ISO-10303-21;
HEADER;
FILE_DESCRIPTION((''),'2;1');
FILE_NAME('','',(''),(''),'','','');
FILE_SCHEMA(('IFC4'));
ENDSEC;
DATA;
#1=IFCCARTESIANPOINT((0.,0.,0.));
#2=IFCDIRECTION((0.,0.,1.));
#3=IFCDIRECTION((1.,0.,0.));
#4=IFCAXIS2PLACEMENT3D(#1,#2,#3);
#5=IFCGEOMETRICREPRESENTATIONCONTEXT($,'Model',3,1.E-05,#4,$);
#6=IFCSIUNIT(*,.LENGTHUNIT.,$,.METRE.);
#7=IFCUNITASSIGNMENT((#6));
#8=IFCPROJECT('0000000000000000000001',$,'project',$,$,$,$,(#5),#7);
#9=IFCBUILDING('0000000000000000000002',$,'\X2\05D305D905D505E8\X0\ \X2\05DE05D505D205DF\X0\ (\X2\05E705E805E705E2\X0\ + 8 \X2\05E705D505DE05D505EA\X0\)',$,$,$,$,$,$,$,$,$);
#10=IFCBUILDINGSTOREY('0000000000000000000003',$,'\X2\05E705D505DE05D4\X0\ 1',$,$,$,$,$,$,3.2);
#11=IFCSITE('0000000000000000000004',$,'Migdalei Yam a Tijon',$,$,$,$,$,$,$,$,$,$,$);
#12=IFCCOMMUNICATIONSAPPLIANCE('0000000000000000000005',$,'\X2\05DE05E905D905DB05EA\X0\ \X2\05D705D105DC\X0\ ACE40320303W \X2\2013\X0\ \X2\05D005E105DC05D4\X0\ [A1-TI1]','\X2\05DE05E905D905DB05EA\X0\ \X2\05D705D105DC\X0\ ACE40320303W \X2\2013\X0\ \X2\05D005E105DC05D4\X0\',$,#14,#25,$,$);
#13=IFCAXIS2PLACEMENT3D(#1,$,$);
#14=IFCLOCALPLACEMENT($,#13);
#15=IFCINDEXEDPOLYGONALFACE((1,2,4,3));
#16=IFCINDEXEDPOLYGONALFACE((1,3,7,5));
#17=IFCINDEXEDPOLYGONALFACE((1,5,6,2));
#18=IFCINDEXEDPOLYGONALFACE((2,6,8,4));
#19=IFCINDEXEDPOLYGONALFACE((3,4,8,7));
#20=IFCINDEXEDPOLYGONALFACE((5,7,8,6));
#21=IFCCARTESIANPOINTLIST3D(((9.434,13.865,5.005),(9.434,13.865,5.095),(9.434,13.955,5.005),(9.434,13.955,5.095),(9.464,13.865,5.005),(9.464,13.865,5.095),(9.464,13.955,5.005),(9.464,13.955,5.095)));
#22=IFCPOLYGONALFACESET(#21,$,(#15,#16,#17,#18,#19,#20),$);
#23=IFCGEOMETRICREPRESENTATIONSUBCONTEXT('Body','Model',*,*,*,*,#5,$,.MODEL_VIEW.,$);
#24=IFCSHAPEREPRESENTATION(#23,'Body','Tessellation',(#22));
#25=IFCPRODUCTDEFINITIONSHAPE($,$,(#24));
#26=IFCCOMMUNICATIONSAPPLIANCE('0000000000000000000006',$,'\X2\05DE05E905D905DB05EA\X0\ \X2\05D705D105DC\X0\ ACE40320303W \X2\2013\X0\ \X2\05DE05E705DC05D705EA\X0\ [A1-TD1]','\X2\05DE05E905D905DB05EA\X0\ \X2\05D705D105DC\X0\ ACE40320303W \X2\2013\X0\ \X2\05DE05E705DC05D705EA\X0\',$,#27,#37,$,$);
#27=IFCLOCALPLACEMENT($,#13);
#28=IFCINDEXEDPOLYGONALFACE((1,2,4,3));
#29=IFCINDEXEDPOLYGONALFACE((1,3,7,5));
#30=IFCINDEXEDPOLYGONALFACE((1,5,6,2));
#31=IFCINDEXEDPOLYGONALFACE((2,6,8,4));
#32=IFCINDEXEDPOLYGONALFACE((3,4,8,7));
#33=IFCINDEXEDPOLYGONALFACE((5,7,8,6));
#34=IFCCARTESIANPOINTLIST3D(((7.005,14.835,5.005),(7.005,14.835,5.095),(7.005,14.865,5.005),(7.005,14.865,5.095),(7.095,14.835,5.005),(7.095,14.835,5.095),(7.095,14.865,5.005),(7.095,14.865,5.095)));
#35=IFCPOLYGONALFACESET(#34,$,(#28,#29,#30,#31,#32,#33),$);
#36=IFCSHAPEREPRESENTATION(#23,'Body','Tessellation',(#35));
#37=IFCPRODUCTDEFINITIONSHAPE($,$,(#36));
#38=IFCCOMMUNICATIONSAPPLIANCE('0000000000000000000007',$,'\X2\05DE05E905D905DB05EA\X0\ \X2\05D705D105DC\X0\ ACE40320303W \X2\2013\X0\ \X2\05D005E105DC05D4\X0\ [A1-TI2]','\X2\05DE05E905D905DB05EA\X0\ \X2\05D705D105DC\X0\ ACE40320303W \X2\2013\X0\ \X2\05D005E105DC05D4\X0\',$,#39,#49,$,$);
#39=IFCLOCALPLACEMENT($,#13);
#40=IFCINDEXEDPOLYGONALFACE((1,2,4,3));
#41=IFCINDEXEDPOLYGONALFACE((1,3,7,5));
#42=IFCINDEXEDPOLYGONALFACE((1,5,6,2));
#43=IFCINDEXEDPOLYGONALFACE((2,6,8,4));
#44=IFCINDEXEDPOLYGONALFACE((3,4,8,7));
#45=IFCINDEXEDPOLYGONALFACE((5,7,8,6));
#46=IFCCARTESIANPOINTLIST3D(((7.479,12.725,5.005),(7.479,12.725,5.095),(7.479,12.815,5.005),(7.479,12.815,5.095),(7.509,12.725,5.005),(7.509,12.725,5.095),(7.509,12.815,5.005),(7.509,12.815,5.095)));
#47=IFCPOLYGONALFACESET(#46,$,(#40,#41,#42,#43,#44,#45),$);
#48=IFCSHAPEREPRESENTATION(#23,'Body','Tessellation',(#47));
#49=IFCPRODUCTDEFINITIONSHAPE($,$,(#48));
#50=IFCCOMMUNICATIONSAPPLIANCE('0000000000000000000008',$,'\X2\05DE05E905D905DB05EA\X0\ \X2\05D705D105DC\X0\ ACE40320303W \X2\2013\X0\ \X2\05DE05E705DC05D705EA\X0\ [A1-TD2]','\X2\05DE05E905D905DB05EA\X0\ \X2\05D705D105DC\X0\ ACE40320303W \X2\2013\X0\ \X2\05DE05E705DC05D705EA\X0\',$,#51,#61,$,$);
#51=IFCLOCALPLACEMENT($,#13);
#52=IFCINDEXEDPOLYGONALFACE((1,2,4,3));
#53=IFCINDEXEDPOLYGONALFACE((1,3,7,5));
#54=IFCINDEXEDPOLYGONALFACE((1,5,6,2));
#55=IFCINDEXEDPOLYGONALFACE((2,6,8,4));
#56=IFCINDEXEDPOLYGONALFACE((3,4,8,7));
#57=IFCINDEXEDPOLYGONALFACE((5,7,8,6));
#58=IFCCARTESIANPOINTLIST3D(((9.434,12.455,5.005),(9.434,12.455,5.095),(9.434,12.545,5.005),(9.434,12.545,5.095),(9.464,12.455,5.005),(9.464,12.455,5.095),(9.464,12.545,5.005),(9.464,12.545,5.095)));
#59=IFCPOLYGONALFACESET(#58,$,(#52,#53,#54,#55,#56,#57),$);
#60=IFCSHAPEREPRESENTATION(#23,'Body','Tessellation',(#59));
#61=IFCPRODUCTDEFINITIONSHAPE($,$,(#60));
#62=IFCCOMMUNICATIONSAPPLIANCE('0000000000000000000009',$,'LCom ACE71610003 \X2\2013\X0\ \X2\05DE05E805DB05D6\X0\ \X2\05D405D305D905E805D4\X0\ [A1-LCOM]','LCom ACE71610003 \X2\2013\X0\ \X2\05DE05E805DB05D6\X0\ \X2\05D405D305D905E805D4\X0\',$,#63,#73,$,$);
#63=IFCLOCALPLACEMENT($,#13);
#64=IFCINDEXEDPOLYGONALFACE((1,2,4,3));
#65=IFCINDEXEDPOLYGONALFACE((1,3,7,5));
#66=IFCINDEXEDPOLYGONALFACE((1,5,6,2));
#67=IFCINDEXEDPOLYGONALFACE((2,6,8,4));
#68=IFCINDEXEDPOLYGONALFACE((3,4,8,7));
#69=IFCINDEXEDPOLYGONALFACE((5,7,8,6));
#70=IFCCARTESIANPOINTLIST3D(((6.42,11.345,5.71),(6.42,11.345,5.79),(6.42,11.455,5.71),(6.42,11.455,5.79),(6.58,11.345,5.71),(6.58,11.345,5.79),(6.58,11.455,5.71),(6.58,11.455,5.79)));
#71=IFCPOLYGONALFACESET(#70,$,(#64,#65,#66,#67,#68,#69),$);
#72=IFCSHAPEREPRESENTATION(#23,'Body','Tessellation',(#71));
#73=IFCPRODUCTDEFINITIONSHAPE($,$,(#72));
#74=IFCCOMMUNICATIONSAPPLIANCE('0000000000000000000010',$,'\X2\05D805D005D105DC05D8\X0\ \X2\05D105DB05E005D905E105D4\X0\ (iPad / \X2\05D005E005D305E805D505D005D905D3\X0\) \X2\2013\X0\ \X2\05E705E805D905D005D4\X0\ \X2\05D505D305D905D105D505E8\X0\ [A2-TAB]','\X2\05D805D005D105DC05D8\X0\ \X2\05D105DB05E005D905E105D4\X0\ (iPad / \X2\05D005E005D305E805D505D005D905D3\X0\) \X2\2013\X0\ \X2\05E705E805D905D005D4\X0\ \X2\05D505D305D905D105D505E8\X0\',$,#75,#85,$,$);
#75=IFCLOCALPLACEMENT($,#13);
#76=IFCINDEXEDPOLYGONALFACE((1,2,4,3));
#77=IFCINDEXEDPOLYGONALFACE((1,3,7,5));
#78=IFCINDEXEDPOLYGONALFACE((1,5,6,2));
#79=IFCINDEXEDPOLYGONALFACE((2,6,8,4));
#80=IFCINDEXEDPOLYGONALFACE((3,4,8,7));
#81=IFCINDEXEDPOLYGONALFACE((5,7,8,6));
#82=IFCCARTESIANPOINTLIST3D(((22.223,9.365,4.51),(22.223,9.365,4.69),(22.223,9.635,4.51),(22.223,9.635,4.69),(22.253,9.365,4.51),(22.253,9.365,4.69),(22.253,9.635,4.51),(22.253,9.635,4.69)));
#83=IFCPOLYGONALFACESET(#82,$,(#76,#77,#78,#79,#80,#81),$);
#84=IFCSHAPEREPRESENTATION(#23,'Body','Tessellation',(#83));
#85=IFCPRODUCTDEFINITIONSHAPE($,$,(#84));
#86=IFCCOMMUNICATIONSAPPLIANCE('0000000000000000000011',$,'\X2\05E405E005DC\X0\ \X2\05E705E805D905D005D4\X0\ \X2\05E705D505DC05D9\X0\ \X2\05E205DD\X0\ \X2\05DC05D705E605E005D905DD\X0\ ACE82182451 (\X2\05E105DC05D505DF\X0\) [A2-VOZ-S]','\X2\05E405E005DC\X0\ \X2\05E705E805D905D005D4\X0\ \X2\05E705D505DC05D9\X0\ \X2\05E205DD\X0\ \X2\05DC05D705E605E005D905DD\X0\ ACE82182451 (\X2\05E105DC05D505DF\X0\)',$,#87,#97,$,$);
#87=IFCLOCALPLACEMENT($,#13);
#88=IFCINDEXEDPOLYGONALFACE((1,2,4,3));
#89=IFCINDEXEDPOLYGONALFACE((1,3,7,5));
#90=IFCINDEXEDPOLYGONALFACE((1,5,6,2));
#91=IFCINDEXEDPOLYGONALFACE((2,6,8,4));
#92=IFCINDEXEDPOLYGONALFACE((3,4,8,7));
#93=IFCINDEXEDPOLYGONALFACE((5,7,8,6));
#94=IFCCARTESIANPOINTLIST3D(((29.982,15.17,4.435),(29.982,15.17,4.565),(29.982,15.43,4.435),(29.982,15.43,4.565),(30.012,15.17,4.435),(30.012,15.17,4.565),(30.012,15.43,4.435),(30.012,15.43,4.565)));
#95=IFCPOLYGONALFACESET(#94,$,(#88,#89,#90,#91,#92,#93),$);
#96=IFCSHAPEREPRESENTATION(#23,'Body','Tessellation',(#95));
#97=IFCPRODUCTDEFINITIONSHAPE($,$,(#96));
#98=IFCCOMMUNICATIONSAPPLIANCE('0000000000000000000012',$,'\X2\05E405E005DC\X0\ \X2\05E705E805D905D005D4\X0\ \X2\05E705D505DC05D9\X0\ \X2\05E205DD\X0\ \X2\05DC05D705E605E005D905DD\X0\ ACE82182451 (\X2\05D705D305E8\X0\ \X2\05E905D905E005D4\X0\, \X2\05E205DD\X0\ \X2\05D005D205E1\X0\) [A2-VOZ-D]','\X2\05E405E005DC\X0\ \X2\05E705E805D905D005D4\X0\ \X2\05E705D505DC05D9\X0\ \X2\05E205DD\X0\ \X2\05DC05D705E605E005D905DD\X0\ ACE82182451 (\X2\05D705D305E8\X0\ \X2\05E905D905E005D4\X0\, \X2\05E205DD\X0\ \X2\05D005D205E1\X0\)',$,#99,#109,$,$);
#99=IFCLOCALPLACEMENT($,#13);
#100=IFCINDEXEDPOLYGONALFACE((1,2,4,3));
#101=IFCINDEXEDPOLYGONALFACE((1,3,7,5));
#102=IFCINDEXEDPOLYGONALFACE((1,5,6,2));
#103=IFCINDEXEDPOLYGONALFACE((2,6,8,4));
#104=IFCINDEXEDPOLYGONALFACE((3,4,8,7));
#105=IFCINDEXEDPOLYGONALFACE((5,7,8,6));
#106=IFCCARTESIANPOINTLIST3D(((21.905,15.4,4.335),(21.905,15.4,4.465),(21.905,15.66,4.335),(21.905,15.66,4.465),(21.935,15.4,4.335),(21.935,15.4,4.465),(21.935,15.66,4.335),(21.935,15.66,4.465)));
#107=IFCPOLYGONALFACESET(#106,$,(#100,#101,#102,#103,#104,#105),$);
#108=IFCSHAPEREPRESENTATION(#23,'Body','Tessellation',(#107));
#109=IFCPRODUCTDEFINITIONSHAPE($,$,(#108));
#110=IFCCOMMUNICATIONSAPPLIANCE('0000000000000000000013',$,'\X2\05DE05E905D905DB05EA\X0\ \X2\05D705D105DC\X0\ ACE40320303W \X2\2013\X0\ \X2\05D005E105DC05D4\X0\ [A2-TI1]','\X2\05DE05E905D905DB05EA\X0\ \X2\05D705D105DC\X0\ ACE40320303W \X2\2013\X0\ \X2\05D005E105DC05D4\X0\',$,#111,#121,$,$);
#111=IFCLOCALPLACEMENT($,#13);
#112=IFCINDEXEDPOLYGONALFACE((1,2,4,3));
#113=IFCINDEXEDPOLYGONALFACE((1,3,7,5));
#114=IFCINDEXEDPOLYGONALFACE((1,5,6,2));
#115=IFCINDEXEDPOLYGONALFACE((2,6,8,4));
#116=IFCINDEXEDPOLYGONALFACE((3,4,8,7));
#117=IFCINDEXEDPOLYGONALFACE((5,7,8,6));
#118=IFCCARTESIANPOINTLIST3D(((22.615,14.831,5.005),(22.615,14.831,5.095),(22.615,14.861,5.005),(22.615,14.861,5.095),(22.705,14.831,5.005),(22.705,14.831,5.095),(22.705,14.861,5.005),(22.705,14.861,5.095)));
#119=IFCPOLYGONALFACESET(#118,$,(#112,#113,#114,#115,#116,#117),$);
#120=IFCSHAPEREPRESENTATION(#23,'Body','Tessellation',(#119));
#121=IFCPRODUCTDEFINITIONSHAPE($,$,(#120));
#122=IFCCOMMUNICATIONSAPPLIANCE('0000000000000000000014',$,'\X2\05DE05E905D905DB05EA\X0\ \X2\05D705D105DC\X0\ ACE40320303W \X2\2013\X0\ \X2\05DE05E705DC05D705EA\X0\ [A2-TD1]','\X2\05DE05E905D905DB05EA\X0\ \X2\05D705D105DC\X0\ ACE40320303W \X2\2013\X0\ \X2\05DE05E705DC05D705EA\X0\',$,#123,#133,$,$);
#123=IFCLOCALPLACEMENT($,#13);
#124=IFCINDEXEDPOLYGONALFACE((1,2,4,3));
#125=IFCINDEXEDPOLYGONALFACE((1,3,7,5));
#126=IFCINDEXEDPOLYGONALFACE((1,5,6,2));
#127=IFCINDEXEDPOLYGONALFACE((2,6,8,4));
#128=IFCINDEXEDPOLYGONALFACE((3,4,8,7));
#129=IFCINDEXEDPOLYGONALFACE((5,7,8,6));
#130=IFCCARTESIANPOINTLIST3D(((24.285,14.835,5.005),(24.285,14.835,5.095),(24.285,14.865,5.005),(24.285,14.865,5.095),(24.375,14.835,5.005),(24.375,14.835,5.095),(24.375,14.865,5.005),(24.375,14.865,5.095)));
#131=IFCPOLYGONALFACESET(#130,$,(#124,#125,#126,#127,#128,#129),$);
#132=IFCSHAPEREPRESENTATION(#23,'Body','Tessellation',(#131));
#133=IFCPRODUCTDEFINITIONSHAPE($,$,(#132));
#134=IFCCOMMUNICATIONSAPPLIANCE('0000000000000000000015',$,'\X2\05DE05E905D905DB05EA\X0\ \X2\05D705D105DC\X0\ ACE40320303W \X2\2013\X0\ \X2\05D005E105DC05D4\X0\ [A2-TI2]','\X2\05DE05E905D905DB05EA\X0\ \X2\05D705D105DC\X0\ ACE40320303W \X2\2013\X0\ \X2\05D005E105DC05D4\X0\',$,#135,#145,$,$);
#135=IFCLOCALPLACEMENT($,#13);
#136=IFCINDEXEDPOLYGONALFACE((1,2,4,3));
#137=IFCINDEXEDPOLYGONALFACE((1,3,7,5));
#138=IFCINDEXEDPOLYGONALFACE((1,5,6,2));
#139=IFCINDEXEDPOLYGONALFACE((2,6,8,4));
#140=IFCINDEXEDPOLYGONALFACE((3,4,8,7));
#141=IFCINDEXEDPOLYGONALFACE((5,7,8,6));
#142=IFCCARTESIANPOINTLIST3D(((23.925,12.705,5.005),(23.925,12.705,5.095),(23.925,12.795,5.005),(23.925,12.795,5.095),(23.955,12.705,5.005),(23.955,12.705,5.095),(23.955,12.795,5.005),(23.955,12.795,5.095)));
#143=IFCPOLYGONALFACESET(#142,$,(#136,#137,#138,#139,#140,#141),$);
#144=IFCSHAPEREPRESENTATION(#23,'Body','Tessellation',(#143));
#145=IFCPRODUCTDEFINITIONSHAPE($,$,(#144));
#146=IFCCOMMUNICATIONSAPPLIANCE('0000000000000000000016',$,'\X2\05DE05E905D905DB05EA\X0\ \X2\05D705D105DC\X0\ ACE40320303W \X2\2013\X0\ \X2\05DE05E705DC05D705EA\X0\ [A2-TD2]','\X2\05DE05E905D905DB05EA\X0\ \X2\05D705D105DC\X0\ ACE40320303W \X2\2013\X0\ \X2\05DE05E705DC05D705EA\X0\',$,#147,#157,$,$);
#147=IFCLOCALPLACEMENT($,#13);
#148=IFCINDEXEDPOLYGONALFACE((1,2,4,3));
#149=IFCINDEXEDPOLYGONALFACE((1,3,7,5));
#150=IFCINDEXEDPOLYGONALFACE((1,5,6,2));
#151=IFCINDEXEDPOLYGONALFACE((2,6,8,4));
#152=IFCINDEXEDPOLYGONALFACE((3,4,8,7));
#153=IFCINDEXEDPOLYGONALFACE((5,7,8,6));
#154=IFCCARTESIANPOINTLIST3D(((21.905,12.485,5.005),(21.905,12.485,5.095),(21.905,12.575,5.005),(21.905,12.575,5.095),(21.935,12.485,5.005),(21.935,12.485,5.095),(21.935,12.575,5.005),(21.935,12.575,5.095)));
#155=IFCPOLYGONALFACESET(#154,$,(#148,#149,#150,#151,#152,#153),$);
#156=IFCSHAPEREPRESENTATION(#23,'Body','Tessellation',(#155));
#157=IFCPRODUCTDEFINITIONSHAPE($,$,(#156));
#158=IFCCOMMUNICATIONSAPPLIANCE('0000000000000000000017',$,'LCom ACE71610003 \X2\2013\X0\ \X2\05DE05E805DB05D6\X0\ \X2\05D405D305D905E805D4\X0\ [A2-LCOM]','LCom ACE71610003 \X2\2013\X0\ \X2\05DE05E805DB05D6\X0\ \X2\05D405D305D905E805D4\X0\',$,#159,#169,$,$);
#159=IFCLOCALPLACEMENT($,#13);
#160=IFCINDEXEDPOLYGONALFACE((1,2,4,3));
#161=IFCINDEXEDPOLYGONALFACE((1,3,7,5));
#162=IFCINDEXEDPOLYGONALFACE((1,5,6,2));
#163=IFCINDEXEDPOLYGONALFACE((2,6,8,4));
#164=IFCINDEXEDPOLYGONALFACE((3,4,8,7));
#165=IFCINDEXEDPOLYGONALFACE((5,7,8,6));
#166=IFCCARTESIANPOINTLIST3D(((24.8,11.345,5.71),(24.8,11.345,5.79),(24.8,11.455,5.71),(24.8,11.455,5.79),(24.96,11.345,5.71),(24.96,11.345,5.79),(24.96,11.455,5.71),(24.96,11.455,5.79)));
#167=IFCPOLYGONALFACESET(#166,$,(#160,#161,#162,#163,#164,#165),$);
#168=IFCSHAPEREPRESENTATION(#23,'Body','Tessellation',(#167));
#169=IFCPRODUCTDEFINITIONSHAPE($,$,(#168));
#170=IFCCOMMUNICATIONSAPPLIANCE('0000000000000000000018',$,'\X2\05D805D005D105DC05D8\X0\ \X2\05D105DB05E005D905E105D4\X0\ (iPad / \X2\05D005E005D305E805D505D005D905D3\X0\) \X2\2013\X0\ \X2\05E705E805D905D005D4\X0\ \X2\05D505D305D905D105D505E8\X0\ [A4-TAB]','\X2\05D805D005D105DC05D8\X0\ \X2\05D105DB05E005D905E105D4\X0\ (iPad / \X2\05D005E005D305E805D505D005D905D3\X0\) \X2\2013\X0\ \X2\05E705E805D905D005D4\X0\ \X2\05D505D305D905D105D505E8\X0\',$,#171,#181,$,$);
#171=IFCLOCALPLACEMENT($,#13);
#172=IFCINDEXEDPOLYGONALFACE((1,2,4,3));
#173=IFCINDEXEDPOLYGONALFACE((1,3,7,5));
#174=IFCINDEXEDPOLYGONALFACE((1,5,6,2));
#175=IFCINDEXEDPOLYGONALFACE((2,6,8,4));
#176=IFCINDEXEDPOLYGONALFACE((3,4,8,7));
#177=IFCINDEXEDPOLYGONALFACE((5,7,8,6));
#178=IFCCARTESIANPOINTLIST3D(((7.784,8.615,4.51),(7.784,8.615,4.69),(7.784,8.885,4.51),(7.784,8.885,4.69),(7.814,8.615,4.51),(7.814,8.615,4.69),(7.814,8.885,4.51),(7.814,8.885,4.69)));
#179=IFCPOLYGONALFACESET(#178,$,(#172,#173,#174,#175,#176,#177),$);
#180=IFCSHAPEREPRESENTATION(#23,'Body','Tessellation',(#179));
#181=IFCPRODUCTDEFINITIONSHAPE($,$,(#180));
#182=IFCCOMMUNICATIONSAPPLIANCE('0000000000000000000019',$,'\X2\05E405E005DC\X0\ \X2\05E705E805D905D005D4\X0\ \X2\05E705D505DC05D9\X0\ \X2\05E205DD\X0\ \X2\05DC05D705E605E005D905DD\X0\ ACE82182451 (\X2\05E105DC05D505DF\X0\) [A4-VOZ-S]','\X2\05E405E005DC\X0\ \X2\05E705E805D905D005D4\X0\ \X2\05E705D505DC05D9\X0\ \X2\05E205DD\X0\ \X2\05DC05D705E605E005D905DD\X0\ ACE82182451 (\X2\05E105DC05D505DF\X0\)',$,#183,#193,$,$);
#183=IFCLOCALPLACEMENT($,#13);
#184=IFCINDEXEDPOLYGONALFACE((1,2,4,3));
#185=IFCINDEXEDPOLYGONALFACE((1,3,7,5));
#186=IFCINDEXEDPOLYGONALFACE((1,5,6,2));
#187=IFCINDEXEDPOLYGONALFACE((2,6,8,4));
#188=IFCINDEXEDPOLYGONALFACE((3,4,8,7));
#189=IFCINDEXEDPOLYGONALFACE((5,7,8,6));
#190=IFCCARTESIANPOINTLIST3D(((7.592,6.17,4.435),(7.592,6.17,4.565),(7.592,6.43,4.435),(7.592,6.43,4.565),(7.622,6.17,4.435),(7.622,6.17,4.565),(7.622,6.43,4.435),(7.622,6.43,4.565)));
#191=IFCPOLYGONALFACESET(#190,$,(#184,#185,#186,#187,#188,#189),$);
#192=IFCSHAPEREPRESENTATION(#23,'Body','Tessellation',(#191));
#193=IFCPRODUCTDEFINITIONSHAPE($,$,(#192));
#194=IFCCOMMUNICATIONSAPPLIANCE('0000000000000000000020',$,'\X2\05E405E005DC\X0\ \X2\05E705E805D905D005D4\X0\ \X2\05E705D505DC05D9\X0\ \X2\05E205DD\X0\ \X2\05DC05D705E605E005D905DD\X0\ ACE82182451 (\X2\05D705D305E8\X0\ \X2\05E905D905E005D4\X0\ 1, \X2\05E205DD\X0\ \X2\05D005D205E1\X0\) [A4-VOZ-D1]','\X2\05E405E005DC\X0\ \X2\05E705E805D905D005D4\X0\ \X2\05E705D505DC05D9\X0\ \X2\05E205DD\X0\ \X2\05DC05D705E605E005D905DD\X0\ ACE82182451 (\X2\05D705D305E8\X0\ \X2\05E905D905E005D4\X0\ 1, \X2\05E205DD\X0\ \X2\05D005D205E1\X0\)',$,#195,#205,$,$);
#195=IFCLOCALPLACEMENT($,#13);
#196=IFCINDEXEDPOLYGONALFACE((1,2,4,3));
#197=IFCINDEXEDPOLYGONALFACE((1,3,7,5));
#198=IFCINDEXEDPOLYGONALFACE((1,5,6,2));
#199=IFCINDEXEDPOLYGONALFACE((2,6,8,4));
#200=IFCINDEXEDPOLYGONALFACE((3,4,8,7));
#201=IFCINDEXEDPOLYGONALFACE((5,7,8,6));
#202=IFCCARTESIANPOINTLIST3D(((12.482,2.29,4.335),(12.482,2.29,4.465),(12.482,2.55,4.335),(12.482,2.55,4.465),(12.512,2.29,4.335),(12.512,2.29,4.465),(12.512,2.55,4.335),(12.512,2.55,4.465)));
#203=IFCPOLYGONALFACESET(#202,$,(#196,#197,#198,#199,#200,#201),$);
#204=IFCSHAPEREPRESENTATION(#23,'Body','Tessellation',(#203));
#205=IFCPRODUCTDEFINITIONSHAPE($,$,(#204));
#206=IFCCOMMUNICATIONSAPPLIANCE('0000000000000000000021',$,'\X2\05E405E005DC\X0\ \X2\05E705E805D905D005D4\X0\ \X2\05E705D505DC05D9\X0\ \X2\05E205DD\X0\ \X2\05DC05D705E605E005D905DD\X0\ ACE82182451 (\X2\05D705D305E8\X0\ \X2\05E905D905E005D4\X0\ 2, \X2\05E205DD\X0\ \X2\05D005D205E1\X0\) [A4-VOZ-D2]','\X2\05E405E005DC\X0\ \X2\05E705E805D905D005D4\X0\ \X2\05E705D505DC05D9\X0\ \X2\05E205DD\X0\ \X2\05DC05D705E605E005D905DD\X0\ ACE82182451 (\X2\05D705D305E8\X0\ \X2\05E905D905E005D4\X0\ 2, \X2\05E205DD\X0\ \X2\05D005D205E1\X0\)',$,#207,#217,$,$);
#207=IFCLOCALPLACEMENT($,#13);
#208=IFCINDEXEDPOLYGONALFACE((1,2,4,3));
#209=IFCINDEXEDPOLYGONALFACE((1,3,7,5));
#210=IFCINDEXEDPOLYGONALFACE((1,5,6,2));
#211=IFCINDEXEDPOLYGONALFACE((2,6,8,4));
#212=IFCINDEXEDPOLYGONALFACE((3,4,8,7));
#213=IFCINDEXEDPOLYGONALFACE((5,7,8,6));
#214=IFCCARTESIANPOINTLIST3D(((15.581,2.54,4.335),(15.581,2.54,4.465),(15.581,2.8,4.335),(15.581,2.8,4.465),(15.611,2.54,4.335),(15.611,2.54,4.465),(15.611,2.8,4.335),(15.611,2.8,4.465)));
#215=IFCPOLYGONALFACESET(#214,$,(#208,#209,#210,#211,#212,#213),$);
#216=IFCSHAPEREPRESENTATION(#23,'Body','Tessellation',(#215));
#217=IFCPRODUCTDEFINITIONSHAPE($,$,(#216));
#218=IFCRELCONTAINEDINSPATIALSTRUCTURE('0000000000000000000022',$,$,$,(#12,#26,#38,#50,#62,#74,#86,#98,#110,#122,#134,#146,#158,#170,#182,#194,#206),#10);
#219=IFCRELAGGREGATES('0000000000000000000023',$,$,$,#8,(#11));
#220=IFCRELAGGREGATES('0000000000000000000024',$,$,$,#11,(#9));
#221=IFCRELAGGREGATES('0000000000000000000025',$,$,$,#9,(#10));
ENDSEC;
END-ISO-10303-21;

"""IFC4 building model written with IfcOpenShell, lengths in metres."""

from ifc_helpers import new_model, si_unit, frame, origin_with_axes, context, subcontext, project, spatial, line, indexed_curve, outline, extrude, element, save


model = new_model("IFC4")

# Units and contexts
model_context = context("Model", 3, precision=1e-05, world=origin_with_axes())
body_context = subcontext(model_context, "Body", "Model", "MODEL_VIEW")
ifc_project = project(units=[si_unit("LENGTHUNIT", "METRE")], contexts=[model_context])

# Site, building, storey
site = spatial("IfcSite", under=ifc_project, Name="Migdalei Yam a Tijon")
building = spatial("IfcBuilding", under=site, Name="דיור מוגן (קרקע + 8 קומות)")
storey = spatial("IfcBuildingStorey", under=building, Name="קומה 1", Elevation=3.2)

# Communications appliances
element("IfcCommunicationsAppliance", 1, inside=storey, Name="משיכת חבל ACE40320303W – אסלה [A1-TI1]", Description="משיכת חבל ACE40320303W – אסלה", context=body_context, shape_type="SweptSolid", body=[
    extrude(outline(indexed_curve([(0.0, 0.0), (0.03, 0.0), (0.03, 0.09), (0.0, 0.09)], segments=[line(1, 2, 3, 4, 1)])), frame((9.434, 13.865, 5.005), z_axis=(0.0, 0.0, 1.0), x_axis=(1.0, 0.0, 0.0)), (0.0, 0.0, 1.0), 0.09),
])
element("IfcCommunicationsAppliance", 2, inside=storey, Name="משיכת חבל ACE40320303W – מקלחת [A1-TD1]", Description="משיכת חבל ACE40320303W – מקלחת", context=body_context, shape_type="SweptSolid", body=[
    extrude(outline(indexed_curve([(0.0, 0.0), (0.09, 0.0), (0.09, 0.03), (0.0, 0.03)], segments=[line(1, 2, 3, 4, 1)])), frame((7.005, 14.835, 5.005), z_axis=(0.0, 0.0, 1.0), x_axis=(1.0, 0.0, 0.0)), (0.0, 0.0, 1.0), 0.09),
])
element("IfcCommunicationsAppliance", 3, inside=storey, Name="משיכת חבל ACE40320303W – אסלה [A1-TI2]", Description="משיכת חבל ACE40320303W – אסלה", context=body_context, shape_type="SweptSolid", body=[
    extrude(outline(indexed_curve([(0.0, 0.0), (0.03, 0.0), (0.03, 0.09), (0.0, 0.09)], segments=[line(1, 2, 3, 4, 1)])), frame((7.479, 12.725, 5.005), z_axis=(0.0, 0.0, 1.0), x_axis=(1.0, 0.0, 0.0)), (0.0, 0.0, 1.0), 0.09),
])
element("IfcCommunicationsAppliance", 4, inside=storey, Name="משיכת חבל ACE40320303W – מקלחת [A1-TD2]", Description="משיכת חבל ACE40320303W – מקלחת", context=body_context, shape_type="SweptSolid", body=[
    extrude(outline(indexed_curve([(0.0, 0.0), (0.03, 0.0), (0.03, 0.09), (0.0, 0.09)], segments=[line(1, 2, 3, 4, 1)])), frame((9.434, 12.455, 5.005), z_axis=(0.0, 0.0, 1.0), x_axis=(1.0, 0.0, 0.0)), (0.0, 0.0, 1.0), 0.09),
])
element("IfcCommunicationsAppliance", 5, inside=storey, Name="LCom ACE71610003 – מרכז הדירה [A1-LCOM]", Description="LCom ACE71610003 – מרכז הדירה", context=body_context, shape_type="SweptSolid", body=[
    extrude(outline(indexed_curve([(0.0, 0.0), (0.16, 0.0), (0.16, 0.11), (0.0, 0.11)], segments=[line(1, 2, 3, 4, 1)])), frame((6.42, 11.345, 5.71), z_axis=(0.0, 0.0, 1.0), x_axis=(1.0, 0.0, 0.0)), (0.0, 0.0, 1.0), 0.08),
])
element("IfcCommunicationsAppliance", 6, inside=storey, Name="טאבלט בכניסה (iPad / אנדרואיד) – קריאה ודיבור [A2-TAB]", Description="טאבלט בכניסה (iPad / אנדרואיד) – קריאה ודיבור", context=body_context, shape_type="SweptSolid", body=[
    extrude(outline(indexed_curve([(0.0, 0.0), (0.03, 0.0), (0.03, 0.27), (0.0, 0.27)], segments=[line(1, 2, 3, 4, 1)])), frame((22.223, 9.365, 4.51), z_axis=(0.0, 0.0, 1.0), x_axis=(1.0, 0.0, 0.0)), (0.0, 0.0, 1.0), 0.18),
])
element("IfcCommunicationsAppliance", 7, inside=storey, Name="פנל קריאה קולי עם לחצנים ACE82182451 (סלון) [A2-VOZ-S]", Description="פנל קריאה קולי עם לחצנים ACE82182451 (סלון)", context=body_context, shape_type="SweptSolid", body=[
    extrude(outline(indexed_curve([(0.0, 0.0), (0.03, 0.0), (0.03, 0.26), (0.0, 0.26)], segments=[line(1, 2, 3, 4, 1)])), frame((29.982, 15.17, 4.435), z_axis=(0.0, 0.0, 1.0), x_axis=(1.0, 0.0, 0.0)), (0.0, 0.0, 1.0), 0.13),
])
element("IfcCommunicationsAppliance", 8, inside=storey, Name="פנל קריאה קולי עם לחצנים ACE82182451 (חדר שינה, עם אגס) [A2-VOZ-D]", Description="פנל קריאה קולי עם לחצנים ACE82182451 (חדר שינה, עם אגס)", context=body_context, shape_type="SweptSolid", body=[
    extrude(outline(indexed_curve([(0.0, 0.0), (0.03, 0.0), (0.03, 0.26), (0.0, 0.26)], segments=[line(1, 2, 3, 4, 1)])), frame((21.905, 15.4, 4.335), z_axis=(0.0, 0.0, 1.0), x_axis=(1.0, 0.0, 0.0)), (0.0, 0.0, 1.0), 0.13),
])
element("IfcCommunicationsAppliance", 9, inside=storey, Name="משיכת חבל ACE40320303W – אסלה [A2-TI1]", Description="משיכת חבל ACE40320303W – אסלה", context=body_context, shape_type="SweptSolid", body=[
    extrude(outline(indexed_curve([(0.0, 0.0), (0.09, 0.0), (0.09, 0.03), (0.0, 0.03)], segments=[line(1, 2, 3, 4, 1)])), frame((22.615, 14.831, 5.005), z_axis=(0.0, 0.0, 1.0), x_axis=(1.0, 0.0, 0.0)), (0.0, 0.0, 1.0), 0.09),
])
element("IfcCommunicationsAppliance", 10, inside=storey, Name="משיכת חבל ACE40320303W – מקלחת [A2-TD1]", Description="משיכת חבל ACE40320303W – מקלחת", context=body_context, shape_type="SweptSolid", body=[
    extrude(outline(indexed_curve([(0.0, 0.0), (0.09, 0.0), (0.09, 0.03), (0.0, 0.03)], segments=[line(1, 2, 3, 4, 1)])), frame((24.285, 14.835, 5.005), z_axis=(0.0, 0.0, 1.0), x_axis=(1.0, 0.0, 0.0)), (0.0, 0.0, 1.0), 0.09),
])
element("IfcCommunicationsAppliance", 11, inside=storey, Name="משיכת חבל ACE40320303W – אסלה [A2-TI2]", Description="משיכת חבל ACE40320303W – אסלה", context=body_context, shape_type="SweptSolid", body=[
    extrude(outline(indexed_curve([(0.0, 0.0), (0.03, 0.0), (0.03, 0.09), (0.0, 0.09)], segments=[line(1, 2, 3, 4, 1)])), frame((23.925, 12.705, 5.005), z_axis=(0.0, 0.0, 1.0), x_axis=(1.0, 0.0, 0.0)), (0.0, 0.0, 1.0), 0.09),
])
element("IfcCommunicationsAppliance", 12, inside=storey, Name="משיכת חבל ACE40320303W – מקלחת [A2-TD2]", Description="משיכת חבל ACE40320303W – מקלחת", context=body_context, shape_type="SweptSolid", body=[
    extrude(outline(indexed_curve([(0.0, 0.0), (0.03, 0.0), (0.03, 0.09), (0.0, 0.09)], segments=[line(1, 2, 3, 4, 1)])), frame((21.905, 12.485, 5.005), z_axis=(0.0, 0.0, 1.0), x_axis=(1.0, 0.0, 0.0)), (0.0, 0.0, 1.0), 0.09),
])
element("IfcCommunicationsAppliance", 13, inside=storey, Name="LCom ACE71610003 – מרכז הדירה [A2-LCOM]", Description="LCom ACE71610003 – מרכז הדירה", context=body_context, shape_type="SweptSolid", body=[
    extrude(outline(indexed_curve([(0.0, 0.0), (0.16, 0.0), (0.16, 0.11), (0.0, 0.11)], segments=[line(1, 2, 3, 4, 1)])), frame((24.8, 11.345, 5.71), z_axis=(0.0, 0.0, 1.0), x_axis=(1.0, 0.0, 0.0)), (0.0, 0.0, 1.0), 0.08),
])
element("IfcCommunicationsAppliance", 14, inside=storey, Name="טאבלט בכניסה (iPad / אנדרואיד) – קריאה ודיבור [A4-TAB]", Description="טאבלט בכניסה (iPad / אנדרואיד) – קריאה ודיבור", context=body_context, shape_type="SweptSolid", body=[
    extrude(outline(indexed_curve([(0.0, 0.0), (0.03, 0.0), (0.03, 0.27), (0.0, 0.27)], segments=[line(1, 2, 3, 4, 1)])), frame((7.784, 8.615, 4.51), z_axis=(0.0, 0.0, 1.0), x_axis=(1.0, 0.0, 0.0)), (0.0, 0.0, 1.0), 0.18),
])
element("IfcCommunicationsAppliance", 15, inside=storey, Name="פנל קריאה קולי עם לחצנים ACE82182451 (סלון) [A4-VOZ-S]", Description="פנל קריאה קולי עם לחצנים ACE82182451 (סלון)", context=body_context, shape_type="SweptSolid", body=[
    extrude(outline(indexed_curve([(0.0, 0.0), (0.03, 0.0), (0.03, 0.26), (0.0, 0.26)], segments=[line(1, 2, 3, 4, 1)])), frame((7.592, 6.17, 4.435), z_axis=(0.0, 0.0, 1.0), x_axis=(1.0, 0.0, 0.0)), (0.0, 0.0, 1.0), 0.13),
])
element("IfcCommunicationsAppliance", 16, inside=storey, Name="פנל קריאה קולי עם לחצנים ACE82182451 (חדר שינה 1, עם אגס) [A4-VOZ-D1]", Description="פנל קריאה קולי עם לחצנים ACE82182451 (חדר שינה 1, עם אגס)", context=body_context, shape_type="SweptSolid", body=[
    extrude(outline(indexed_curve([(0.0, 0.0), (0.03, 0.0), (0.03, 0.26), (0.0, 0.26)], segments=[line(1, 2, 3, 4, 1)])), frame((12.482, 2.29, 4.335), z_axis=(0.0, 0.0, 1.0), x_axis=(1.0, 0.0, 0.0)), (0.0, 0.0, 1.0), 0.13),
])
element("IfcCommunicationsAppliance", 17, inside=storey, Name="פנל קריאה קולי עם לחצנים ACE82182451 (חדר שינה 2, עם אגס) [A4-VOZ-D2]", Description="פנל קריאה קולי עם לחצנים ACE82182451 (חדר שינה 2, עם אגס)", context=body_context, shape_type="SweptSolid", body=[
    extrude(outline(indexed_curve([(0.0, 0.0), (0.03, 0.0), (0.03, 0.26), (0.0, 0.26)], segments=[line(1, 2, 3, 4, 1)])), frame((15.581, 2.54, 4.335), z_axis=(0.0, 0.0, 1.0), x_axis=(1.0, 0.0, 0.0)), (0.0, 0.0, 1.0), 0.13),
])

save(model, "model.ifc")
